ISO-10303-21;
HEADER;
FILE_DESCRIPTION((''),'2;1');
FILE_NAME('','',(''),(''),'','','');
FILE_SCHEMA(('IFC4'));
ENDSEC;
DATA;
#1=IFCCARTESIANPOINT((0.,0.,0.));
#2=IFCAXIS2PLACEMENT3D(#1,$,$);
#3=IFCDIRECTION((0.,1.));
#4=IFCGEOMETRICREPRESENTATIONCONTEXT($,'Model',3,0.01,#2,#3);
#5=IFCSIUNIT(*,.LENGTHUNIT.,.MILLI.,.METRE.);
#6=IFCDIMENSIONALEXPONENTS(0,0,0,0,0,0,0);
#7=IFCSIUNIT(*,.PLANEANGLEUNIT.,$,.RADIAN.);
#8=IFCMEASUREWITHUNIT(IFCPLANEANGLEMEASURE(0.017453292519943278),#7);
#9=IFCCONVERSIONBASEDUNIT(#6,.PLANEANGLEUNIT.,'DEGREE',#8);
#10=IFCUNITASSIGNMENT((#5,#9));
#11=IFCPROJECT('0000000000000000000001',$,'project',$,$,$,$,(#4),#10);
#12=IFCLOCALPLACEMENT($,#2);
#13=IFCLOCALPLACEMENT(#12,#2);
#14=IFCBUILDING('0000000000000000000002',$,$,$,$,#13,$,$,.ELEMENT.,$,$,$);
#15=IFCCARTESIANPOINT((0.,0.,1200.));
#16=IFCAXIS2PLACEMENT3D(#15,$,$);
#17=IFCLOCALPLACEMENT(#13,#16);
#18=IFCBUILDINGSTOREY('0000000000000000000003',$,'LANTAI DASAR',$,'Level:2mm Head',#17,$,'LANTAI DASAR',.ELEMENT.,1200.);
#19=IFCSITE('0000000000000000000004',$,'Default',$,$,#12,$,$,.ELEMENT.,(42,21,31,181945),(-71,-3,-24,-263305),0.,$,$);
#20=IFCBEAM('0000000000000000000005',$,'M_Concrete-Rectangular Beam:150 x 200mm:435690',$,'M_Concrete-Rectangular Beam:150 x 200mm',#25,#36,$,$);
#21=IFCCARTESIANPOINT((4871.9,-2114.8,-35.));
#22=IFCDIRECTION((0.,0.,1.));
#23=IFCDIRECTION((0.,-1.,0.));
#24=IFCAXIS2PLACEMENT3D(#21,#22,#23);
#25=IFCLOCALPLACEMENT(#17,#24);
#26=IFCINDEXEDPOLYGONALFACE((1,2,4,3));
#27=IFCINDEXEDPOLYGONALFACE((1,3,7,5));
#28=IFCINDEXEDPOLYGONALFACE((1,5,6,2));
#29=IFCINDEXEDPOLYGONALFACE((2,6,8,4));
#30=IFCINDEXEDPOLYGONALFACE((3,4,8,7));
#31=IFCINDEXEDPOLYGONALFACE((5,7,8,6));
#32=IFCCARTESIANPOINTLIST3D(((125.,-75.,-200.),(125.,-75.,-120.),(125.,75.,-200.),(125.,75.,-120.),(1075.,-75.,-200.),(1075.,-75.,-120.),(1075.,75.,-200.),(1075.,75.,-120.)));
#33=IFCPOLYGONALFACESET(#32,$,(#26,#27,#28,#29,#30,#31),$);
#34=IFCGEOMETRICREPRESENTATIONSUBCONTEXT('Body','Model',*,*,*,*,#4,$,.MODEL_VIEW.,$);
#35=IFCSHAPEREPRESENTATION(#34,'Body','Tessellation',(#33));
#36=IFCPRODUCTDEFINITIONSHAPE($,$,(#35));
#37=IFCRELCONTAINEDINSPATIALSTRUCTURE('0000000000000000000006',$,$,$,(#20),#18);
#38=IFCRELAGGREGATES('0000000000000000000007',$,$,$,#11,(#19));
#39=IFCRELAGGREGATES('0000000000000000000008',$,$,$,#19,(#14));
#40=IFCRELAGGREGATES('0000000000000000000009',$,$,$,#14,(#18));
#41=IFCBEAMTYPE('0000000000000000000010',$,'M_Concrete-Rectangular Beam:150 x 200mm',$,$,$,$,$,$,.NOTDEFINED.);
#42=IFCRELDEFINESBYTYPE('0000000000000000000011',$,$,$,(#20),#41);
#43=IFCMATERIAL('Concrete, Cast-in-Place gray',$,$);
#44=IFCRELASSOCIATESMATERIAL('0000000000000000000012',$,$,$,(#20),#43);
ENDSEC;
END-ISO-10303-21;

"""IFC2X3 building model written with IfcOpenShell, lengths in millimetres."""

from ifc_helpers import new_model, entity, si_unit, converted_unit, direction, frame, frame_2d, origin, place, context, subcontext, project, spatial, rectangle, extrude, material, type_object, element, save


model = new_model("IFC2X3")

# Units and contexts
model_context = context("Model", 3, precision=0.01, world=origin(), true_north=direction((0.0, 1.0)))
body_context = subcontext(model_context, "Body", "Model", "MODEL_VIEW")
ifc_project = project(units=[si_unit("LENGTHUNIT", "METRE", prefix="MILLI"), converted_unit("PLANEANGLEUNIT", "DEGREE", entity("IfcPlaneAngleMeasure", 0.017453292519943278), si_unit("PLANEANGLEUNIT", "RADIAN"), dimensions=[0, 0, 0, 0, 0, 0, 0])], contexts=[model_context])

# Site, building, storey
site_placement = place(None, origin())
site = spatial("IfcSite", under=ifc_project, at=site_placement, Name="Default", CompositionType="ELEMENT", RefLatitude=(42, 21, 31, 181945), RefLongitude=(-71, -3, -24, -263305), RefElevation=0.0)
building_placement = place(site_placement, origin())
building = spatial("IfcBuilding", under=site, at=building_placement, CompositionType="ELEMENT")
storey_placement = place(building_placement, frame((0.0, 0.0, 1200.0)))
storey = spatial("IfcBuildingStorey", under=building, at=storey_placement, Name="LANTAI DASAR", ObjectType="Level:2mm Head", LongName="LANTAI DASAR", CompositionType="ELEMENT", Elevation=1200.0)

# Shared definitions
ifc_material = material(Name="Concrete, Cast-in-Place gray")

# Beam
beam_type = type_object("IfcBeamType", Name="M_Concrete-Rectangular Beam:150 x 200mm", PredefinedType="NOTDEFINED")
beam_1_placement = place(storey_placement, frame((4871.9, -2114.8, -35.0), z_axis=(0.0, 0.0, 1.0), x_axis=(0.0, -1.0, 0.0)))
element("IfcBeam", 1, at=beam_1_placement, inside=storey, type_object=beam_type, material=ifc_material, Name="M_Concrete-Rectangular Beam:150 x 200mm:435690", ObjectType="M_Concrete-Rectangular Beam:150 x 200mm", context=body_context, shape_type="SweptSolid", body=[
    extrude(rectangle(XDim=80.0, YDim=150.0, at=frame_2d((0.0, 0.0), x_axis=(1.0, 0.0))), frame((125.0, 0.0, -160.0), z_axis=(1.0, 0.0, 0.0), x_axis=(0.0, 0.0, -1.0)), (0.0, 0.0, 1.0), 950.0),
])

save(model, "model.ifc")
